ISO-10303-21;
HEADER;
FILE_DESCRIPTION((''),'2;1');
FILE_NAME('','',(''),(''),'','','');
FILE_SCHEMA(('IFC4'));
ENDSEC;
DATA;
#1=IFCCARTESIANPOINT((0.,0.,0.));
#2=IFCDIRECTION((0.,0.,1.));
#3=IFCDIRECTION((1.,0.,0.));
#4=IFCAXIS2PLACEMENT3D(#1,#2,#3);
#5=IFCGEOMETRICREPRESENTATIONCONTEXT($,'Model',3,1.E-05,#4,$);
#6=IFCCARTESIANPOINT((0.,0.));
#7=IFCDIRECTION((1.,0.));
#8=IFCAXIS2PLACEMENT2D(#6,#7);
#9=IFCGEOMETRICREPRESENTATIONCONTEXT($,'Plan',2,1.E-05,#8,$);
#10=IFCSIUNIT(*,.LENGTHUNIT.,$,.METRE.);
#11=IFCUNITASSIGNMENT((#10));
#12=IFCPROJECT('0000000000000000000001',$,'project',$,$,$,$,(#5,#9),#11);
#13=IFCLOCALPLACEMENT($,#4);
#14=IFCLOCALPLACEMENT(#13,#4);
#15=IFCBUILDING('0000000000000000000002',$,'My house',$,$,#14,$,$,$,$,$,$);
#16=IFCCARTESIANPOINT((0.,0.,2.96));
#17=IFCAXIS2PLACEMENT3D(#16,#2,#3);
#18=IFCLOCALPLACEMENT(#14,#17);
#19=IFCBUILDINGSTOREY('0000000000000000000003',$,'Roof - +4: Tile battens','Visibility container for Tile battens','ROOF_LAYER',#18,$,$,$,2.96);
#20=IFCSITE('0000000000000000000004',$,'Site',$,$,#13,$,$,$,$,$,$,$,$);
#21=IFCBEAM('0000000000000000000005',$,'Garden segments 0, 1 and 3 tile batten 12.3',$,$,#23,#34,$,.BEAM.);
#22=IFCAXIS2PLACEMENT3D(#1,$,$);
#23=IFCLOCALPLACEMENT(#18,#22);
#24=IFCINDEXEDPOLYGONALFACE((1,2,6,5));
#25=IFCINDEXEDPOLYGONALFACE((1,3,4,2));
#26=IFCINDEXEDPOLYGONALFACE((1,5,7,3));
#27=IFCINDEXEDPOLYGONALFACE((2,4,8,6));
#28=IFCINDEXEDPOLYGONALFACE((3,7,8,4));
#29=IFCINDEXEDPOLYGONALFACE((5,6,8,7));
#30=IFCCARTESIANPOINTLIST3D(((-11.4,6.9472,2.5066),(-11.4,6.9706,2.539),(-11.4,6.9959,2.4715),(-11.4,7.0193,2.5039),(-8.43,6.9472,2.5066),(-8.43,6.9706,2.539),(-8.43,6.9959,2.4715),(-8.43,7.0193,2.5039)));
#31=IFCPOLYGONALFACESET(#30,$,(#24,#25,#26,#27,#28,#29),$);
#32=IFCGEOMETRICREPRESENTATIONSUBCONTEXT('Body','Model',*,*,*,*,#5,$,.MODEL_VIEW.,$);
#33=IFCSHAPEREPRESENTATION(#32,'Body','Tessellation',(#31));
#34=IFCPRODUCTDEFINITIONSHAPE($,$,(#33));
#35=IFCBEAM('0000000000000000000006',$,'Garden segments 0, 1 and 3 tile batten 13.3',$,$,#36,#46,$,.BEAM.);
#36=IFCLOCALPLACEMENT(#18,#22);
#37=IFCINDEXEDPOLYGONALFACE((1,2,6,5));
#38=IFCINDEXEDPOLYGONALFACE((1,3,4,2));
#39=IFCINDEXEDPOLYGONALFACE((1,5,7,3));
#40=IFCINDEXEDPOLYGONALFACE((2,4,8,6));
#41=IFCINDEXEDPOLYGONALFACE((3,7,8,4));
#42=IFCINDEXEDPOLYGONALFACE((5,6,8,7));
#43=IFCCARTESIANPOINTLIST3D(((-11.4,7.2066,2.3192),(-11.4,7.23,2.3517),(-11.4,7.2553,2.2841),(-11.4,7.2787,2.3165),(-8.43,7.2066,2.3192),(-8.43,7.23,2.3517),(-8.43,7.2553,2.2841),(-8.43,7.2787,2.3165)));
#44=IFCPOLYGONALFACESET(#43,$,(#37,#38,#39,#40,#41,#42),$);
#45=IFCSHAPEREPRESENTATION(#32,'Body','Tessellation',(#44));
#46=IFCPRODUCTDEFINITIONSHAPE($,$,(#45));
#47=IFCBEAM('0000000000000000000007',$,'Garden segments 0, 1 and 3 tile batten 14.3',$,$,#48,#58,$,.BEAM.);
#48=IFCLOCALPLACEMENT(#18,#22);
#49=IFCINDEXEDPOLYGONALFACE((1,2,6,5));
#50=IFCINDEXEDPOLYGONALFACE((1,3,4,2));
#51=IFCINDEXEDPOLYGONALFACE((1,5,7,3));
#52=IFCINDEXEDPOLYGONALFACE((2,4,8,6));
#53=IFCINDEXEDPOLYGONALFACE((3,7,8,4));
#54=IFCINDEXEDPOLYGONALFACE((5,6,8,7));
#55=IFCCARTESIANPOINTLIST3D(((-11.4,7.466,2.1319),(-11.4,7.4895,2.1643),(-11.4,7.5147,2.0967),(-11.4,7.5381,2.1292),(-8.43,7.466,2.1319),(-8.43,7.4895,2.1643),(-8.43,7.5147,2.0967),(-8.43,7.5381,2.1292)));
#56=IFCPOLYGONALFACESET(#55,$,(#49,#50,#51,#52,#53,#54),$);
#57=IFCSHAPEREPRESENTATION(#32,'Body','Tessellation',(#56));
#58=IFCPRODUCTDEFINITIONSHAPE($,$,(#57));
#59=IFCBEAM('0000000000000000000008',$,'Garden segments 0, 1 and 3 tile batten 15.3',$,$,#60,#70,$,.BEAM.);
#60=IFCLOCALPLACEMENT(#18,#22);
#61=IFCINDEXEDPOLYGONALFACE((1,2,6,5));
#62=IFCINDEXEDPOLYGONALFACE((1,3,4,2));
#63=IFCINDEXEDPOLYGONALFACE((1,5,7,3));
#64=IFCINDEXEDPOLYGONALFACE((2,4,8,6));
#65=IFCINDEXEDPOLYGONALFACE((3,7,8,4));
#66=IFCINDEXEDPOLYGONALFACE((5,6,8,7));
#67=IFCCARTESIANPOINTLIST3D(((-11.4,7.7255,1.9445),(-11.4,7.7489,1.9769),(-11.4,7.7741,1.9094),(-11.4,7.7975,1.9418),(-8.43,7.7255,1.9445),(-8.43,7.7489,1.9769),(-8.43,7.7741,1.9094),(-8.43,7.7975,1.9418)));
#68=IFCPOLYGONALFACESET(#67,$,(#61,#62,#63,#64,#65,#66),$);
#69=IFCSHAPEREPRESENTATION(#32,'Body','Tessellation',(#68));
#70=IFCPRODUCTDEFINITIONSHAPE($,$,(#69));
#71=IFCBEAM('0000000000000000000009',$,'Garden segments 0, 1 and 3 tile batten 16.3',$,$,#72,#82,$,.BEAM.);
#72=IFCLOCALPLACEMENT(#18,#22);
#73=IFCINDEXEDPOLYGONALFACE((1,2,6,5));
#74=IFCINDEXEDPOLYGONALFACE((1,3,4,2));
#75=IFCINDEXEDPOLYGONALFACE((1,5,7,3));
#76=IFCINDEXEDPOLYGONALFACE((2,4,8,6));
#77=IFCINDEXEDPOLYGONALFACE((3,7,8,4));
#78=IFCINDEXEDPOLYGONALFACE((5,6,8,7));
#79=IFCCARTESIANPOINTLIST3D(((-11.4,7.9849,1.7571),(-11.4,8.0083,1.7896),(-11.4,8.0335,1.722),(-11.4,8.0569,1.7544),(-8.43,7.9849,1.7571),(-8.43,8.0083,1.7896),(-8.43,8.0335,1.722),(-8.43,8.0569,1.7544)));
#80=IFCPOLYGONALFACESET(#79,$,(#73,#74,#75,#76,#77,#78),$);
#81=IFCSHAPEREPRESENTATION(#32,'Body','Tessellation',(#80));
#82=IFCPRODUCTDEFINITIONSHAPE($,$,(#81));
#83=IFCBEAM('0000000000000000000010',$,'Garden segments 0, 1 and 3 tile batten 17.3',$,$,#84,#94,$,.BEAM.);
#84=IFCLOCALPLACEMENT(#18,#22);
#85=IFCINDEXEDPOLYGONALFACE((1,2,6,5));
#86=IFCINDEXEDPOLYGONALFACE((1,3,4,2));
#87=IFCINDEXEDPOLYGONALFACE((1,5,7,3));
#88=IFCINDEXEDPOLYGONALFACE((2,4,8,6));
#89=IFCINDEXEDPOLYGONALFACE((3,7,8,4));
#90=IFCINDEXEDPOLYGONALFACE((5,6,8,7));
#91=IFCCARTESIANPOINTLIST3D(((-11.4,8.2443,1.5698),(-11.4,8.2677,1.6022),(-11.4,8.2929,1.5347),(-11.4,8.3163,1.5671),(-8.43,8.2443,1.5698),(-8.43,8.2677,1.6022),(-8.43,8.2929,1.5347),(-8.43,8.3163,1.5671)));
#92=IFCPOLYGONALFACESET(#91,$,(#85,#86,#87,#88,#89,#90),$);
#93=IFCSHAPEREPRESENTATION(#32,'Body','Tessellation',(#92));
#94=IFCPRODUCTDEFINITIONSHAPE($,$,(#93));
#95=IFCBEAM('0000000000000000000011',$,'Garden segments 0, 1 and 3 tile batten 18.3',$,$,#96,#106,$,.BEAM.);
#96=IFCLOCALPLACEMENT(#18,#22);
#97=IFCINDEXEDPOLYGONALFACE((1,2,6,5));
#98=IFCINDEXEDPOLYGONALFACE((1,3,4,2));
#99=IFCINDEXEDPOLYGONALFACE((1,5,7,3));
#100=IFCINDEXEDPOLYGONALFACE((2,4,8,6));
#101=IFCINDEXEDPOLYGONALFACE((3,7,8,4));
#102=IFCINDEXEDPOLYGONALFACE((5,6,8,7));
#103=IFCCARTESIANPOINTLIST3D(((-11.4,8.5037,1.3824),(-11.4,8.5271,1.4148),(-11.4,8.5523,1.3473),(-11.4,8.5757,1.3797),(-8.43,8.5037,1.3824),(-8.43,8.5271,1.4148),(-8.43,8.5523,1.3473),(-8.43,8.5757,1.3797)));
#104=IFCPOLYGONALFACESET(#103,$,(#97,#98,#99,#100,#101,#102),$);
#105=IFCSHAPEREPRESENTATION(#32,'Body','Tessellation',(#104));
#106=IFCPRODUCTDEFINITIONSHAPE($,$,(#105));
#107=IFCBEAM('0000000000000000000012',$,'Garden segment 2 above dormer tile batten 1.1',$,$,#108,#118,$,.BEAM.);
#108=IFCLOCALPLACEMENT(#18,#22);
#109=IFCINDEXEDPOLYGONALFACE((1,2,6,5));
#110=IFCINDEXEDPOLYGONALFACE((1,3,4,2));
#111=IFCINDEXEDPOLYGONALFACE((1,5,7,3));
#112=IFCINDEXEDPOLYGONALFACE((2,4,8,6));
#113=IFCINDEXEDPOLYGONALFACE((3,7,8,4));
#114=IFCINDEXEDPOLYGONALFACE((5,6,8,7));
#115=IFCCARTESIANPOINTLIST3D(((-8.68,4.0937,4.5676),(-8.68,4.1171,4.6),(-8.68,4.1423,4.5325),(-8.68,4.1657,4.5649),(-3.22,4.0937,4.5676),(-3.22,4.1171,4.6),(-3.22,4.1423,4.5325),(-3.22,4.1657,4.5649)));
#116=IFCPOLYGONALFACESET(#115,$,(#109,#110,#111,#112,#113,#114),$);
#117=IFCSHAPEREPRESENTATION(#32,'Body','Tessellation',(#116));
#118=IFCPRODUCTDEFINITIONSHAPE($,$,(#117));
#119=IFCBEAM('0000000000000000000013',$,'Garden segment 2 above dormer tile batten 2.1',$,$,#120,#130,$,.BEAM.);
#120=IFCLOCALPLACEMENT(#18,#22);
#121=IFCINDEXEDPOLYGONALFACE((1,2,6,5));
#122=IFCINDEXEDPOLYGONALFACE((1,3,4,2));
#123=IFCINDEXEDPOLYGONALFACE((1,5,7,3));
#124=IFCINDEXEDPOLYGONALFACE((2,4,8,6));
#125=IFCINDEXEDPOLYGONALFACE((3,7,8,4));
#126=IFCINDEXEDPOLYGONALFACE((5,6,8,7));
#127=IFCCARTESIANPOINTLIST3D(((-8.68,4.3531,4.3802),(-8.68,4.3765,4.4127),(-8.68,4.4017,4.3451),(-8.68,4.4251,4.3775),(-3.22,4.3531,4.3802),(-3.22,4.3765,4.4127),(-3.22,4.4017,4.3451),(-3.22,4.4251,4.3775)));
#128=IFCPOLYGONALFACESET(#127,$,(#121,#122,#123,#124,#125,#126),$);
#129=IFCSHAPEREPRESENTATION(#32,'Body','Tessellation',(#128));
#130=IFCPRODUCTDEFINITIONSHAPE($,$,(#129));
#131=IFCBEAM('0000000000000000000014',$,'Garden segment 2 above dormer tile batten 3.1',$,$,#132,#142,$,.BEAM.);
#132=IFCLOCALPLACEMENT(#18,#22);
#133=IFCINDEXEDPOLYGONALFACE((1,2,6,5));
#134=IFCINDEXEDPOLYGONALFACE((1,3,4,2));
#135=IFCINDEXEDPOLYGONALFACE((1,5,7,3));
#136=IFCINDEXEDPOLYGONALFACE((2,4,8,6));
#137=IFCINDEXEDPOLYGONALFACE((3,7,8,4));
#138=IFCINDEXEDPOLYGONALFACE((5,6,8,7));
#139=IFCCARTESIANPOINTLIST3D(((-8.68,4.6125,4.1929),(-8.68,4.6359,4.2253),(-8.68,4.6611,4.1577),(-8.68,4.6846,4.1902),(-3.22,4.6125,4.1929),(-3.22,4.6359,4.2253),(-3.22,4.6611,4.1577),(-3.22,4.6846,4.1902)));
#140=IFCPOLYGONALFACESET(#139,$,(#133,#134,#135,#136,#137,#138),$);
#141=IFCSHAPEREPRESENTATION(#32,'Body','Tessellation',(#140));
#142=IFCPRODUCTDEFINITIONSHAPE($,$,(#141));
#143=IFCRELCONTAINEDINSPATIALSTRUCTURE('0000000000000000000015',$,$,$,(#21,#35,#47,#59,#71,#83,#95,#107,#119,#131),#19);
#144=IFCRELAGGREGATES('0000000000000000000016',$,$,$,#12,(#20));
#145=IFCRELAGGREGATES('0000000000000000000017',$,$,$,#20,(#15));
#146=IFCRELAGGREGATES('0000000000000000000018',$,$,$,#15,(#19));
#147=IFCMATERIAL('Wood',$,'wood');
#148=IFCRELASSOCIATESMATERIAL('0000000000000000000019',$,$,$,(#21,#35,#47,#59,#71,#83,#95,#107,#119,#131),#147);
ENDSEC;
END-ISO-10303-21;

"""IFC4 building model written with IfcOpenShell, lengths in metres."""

from ifc_helpers import new_model, si_unit, frame, origin_with_axes, origin_2d_with_axis, place, context, subcontext, project, spatial, rectangle, extrude, clip, halfspace, source, transform, mapped, material, element, save


model = new_model("IFC4")

# Units and contexts
model_context = context("Model", 3, precision=1e-05, world=origin_with_axes())
plan_context = context("Plan", 2, precision=1e-05, world=origin_2d_with_axis())
body_context = subcontext(model_context, "Body", "Model", "MODEL_VIEW")
ifc_project = project(units=[si_unit("LENGTHUNIT", "METRE")], contexts=[model_context, plan_context])

# Site, building, storey
site_placement = place(None, origin_with_axes())
site = spatial("IfcSite", under=ifc_project, at=site_placement, Name="Site")
building_placement = place(site_placement, origin_with_axes())
building = spatial("IfcBuilding", under=site, at=building_placement, Name="My house")
storey_placement = place(building_placement, frame((0.0, 0.0, 2.96), z_axis=(0.0, 0.0, 1.0), x_axis=(1.0, 0.0, 0.0)))
storey = spatial("IfcBuildingStorey", under=building, at=storey_placement, Name="Roof - +4: Tile battens", Description="Visibility container for Tile battens", ObjectType="ROOF_LAYER", Elevation=2.96)

# Beams
ifc_material = material(Name="Wood", Category="wood")
shared_shape_1 = source(origin_with_axes(), body_context, "Body", "Clipping", [
    clip(clip(extrude(rectangle(XDim=0.06, YDim=0.04), frame((0.0, 0.0, 0.0), z_axis=(1.0, 0.0, 0.0), x_axis=(0.0, 1.0, 0.0)), (0.0, 0.0, 1.0), 2.97), halfspace(frame((-8.43, 0.7816, -6.1772), z_axis=(0.0, -0.810664, -0.585512), x_axis=(-1.0, 0.0, 0.0)), False)), halfspace(frame((-8.43, 4.6322, -3.396), z_axis=(0.0, 0.810664, 0.585512), x_axis=(1.0, 0.0, 0.0)), False)),
])
beam_1_placement = place(storey_placement, frame((-8.43, 6.9832, 2.5053), z_axis=(0.0, 0.585512, 0.810664), x_axis=(1.0, 0.0, 0.0)))
element("IfcBeam", 1, at=beam_1_placement, inside=storey, material=ifc_material, Name="Garden segments 0, 1 and 3 tile batten 12.3", PredefinedType="BEAM", context=body_context, shape_type="MappedRepresentation", body=[
    mapped(shared_shape_1, transform((0.0, 0.0, 0.0), x_axis=(-1.0, 0.0, 0.0), y_axis=(0.0, 1.0, 0.0), z_axis=(0.0, 0.0, 1.0), scale=1.0)),
])
shared_shape_2 = source(origin_with_axes(), body_context, "Body", "Clipping", [
    clip(clip(extrude(rectangle(XDim=0.06, YDim=0.04), frame((0.0, 0.0, 0.0), z_axis=(1.0, 0.0, 0.0), x_axis=(0.0, 1.0, 0.0)), (0.0, 0.0, 1.0), 2.97), halfspace(frame((-8.43, 0.4616, -6.1772), z_axis=(0.0, -0.810664, -0.585512), x_axis=(-1.0, 0.0, 0.0)), False)), halfspace(frame((-8.43, 4.3122, -3.396), z_axis=(0.0, 0.810664, 0.585512), x_axis=(1.0, 0.0, 0.0)), False)),
])
beam_2_placement = place(storey_placement, frame((-8.43, 7.2427, 2.3179), z_axis=(0.0, 0.585512, 0.810664), x_axis=(1.0, 0.0, 0.0)))
element("IfcBeam", 2, at=beam_2_placement, inside=storey, material=ifc_material, Name="Garden segments 0, 1 and 3 tile batten 13.3", PredefinedType="BEAM", context=body_context, shape_type="MappedRepresentation", body=[
    mapped(shared_shape_2, transform((0.0, 0.0, 0.0), x_axis=(-1.0, 0.0, 0.0), y_axis=(0.0, 1.0, 0.0), z_axis=(0.0, 0.0, 1.0), scale=1.0)),
])
shared_shape_3 = source(origin_with_axes(), body_context, "Body", "Clipping", [
    clip(clip(extrude(rectangle(XDim=0.06, YDim=0.04), frame((0.0, 0.0, 0.0), z_axis=(1.0, 0.0, 0.0), x_axis=(0.0, 1.0, 0.0)), (0.0, 0.0, 1.0), 2.97), halfspace(frame((-8.43, 0.1416, -6.1772), z_axis=(0.0, -0.810664, -0.585512), x_axis=(-1.0, 0.0, 0.0)), False)), halfspace(frame((-8.43, 3.9922, -3.396), z_axis=(0.0, 0.810664, 0.585512), x_axis=(1.0, 0.0, 0.0)), False)),
])
beam_3_placement = place(storey_placement, frame((-8.43, 7.5021, 2.1305), z_axis=(0.0, 0.585512, 0.810664), x_axis=(1.0, 0.0, 0.0)))
element("IfcBeam", 3, at=beam_3_placement, inside=storey, material=ifc_material, Name="Garden segments 0, 1 and 3 tile batten 14.3", PredefinedType="BEAM", context=body_context, shape_type="MappedRepresentation", body=[
    mapped(shared_shape_3, transform((0.0, 0.0, 0.0), x_axis=(-1.0, 0.0, 0.0), y_axis=(0.0, 1.0, 0.0), z_axis=(0.0, 0.0, 1.0), scale=1.0)),
])
shared_shape_4 = source(origin_with_axes(), body_context, "Body", "Clipping", [
    clip(clip(extrude(rectangle(XDim=0.06, YDim=0.04), frame((0.0, 0.0, 0.0), z_axis=(1.0, 0.0, 0.0), x_axis=(0.0, 1.0, 0.0)), (0.0, 0.0, 1.0), 2.97), halfspace(frame((-8.43, -0.1784, -6.1772), z_axis=(0.0, -0.810664, -0.585512), x_axis=(-1.0, 0.0, 0.0)), False)), halfspace(frame((-8.43, 3.6722, -3.396), z_axis=(0.0, 0.810664, 0.585512), x_axis=(1.0, 0.0, 0.0)), False)),
])
beam_4_placement = place(storey_placement, frame((-8.43, 7.7615, 1.9432), z_axis=(0.0, 0.585512, 0.810664), x_axis=(1.0, 0.0, 0.0)))
element("IfcBeam", 4, at=beam_4_placement, inside=storey, material=ifc_material, Name="Garden segments 0, 1 and 3 tile batten 15.3", PredefinedType="BEAM", context=body_context, shape_type="MappedRepresentation", body=[
    mapped(shared_shape_4, transform((0.0, 0.0, 0.0), x_axis=(-1.0, 0.0, 0.0), y_axis=(0.0, 1.0, 0.0), z_axis=(0.0, 0.0, 1.0), scale=1.0)),
])
shared_shape_5 = source(origin_with_axes(), body_context, "Body", "Clipping", [
    clip(clip(extrude(rectangle(XDim=0.06, YDim=0.04), frame((0.0, 0.0, 0.0), z_axis=(1.0, 0.0, 0.0), x_axis=(0.0, 1.0, 0.0)), (0.0, 0.0, 1.0), 2.97), halfspace(frame((-8.43, -0.4984, -6.1772), z_axis=(0.0, -0.810664, -0.585512), x_axis=(-1.0, 0.0, 0.0)), False)), halfspace(frame((-8.43, 3.3522, -3.396), z_axis=(0.0, 0.810664, 0.585512), x_axis=(1.0, 0.0, 0.0)), False)),
])
beam_5_placement = place(storey_placement, frame((-8.43, 8.0209, 1.7558), z_axis=(0.0, 0.585512, 0.810664), x_axis=(1.0, 0.0, 0.0)))
element("IfcBeam", 5, at=beam_5_placement, inside=storey, material=ifc_material, Name="Garden segments 0, 1 and 3 tile batten 16.3", PredefinedType="BEAM", context=body_context, shape_type="MappedRepresentation", body=[
    mapped(shared_shape_5, transform((0.0, 0.0, 0.0), x_axis=(-1.0, 0.0, 0.0), y_axis=(0.0, 1.0, 0.0), z_axis=(0.0, 0.0, 1.0), scale=1.0)),
])
shared_shape_6 = source(origin_with_axes(), body_context, "Body", "Clipping", [
    clip(clip(extrude(rectangle(XDim=0.06, YDim=0.04), frame((0.0, 0.0, 0.0), z_axis=(1.0, 0.0, 0.0), x_axis=(0.0, 1.0, 0.0)), (0.0, 0.0, 1.0), 2.97), halfspace(frame((-8.43, -0.8184, -6.1772), z_axis=(0.0, -0.810664, -0.585512), x_axis=(-1.0, 0.0, 0.0)), False)), halfspace(frame((-8.43, 3.0322, -3.396), z_axis=(0.0, 0.810664, 0.585512), x_axis=(1.0, 0.0, 0.0)), False)),
])
beam_6_placement = place(storey_placement, frame((-8.43, 8.2803, 1.5684), z_axis=(0.0, 0.585512, 0.810664), x_axis=(1.0, 0.0, 0.0)))
element("IfcBeam", 6, at=beam_6_placement, inside=storey, material=ifc_material, Name="Garden segments 0, 1 and 3 tile batten 17.3", PredefinedType="BEAM", context=body_context, shape_type="MappedRepresentation", body=[
    mapped(shared_shape_6, transform((0.0, 0.0, 0.0), x_axis=(-1.0, 0.0, 0.0), y_axis=(0.0, 1.0, 0.0), z_axis=(0.0, 0.0, 1.0), scale=1.0)),
])
shared_shape_7 = source(origin_with_axes(), body_context, "Body", "Clipping", [
    clip(clip(extrude(rectangle(XDim=0.06, YDim=0.04), frame((0.0, 0.0, 0.0), z_axis=(1.0, 0.0, 0.0), x_axis=(0.0, 1.0, 0.0)), (0.0, 0.0, 1.0), 2.97), halfspace(frame((-8.43, -1.1384, -6.1772), z_axis=(0.0, -0.810664, -0.585512), x_axis=(-1.0, 0.0, 0.0)), False)), halfspace(frame((-8.43, 2.7122, -3.396), z_axis=(0.0, 0.810664, 0.585512), x_axis=(1.0, 0.0, 0.0)), False)),
])
beam_7_placement = place(storey_placement, frame((-8.43, 8.5397, 1.3811), z_axis=(0.0, 0.585512, 0.810664), x_axis=(1.0, 0.0, 0.0)))
element("IfcBeam", 7, at=beam_7_placement, inside=storey, material=ifc_material, Name="Garden segments 0, 1 and 3 tile batten 18.3", PredefinedType="BEAM", context=body_context, shape_type="MappedRepresentation", body=[
    mapped(shared_shape_7, transform((0.0, 0.0, 0.0), x_axis=(-1.0, 0.0, 0.0), y_axis=(0.0, 1.0, 0.0), z_axis=(0.0, 0.0, 1.0), scale=1.0)),
])
shared_shape_8 = source(origin_with_axes(), body_context, "Body", "Clipping", [
    clip(clip(extrude(rectangle(XDim=0.06, YDim=0.04), frame((0.0, 0.0, 0.0), z_axis=(1.0, 0.0, 0.0), x_axis=(0.0, 1.0, 0.0)), (0.0, 0.0, 1.0), 5.46), halfspace(frame((-3.22, 4.3016, -6.1772), z_axis=(0.0, -0.810664, -0.585512), x_axis=(-1.0, 0.0, 0.0)), False)), halfspace(frame((-3.22, 8.1522, -3.396), z_axis=(0.0, 0.810664, 0.585512), x_axis=(1.0, 0.0, 0.0)), False)),
])
beam_8_placement = place(storey_placement, frame((-3.22, 4.1297, 4.5663), z_axis=(0.0, 0.585512, 0.810664), x_axis=(1.0, 0.0, 0.0)))
element("IfcBeam", 8, at=beam_8_placement, inside=storey, material=ifc_material, Name="Garden segment 2 above dormer tile batten 1.1", PredefinedType="BEAM", context=body_context, shape_type="MappedRepresentation", body=[
    mapped(shared_shape_8, transform((0.0, 0.0, 0.0), x_axis=(-1.0, 0.0, 0.0), y_axis=(0.0, 1.0, 0.0), z_axis=(0.0, 0.0, 1.0), scale=1.0)),
])
shared_shape_9 = source(origin_with_axes(), body_context, "Body", "Clipping", [
    clip(clip(extrude(rectangle(XDim=0.06, YDim=0.04), frame((0.0, 0.0, 0.0), z_axis=(1.0, 0.0, 0.0), x_axis=(0.0, 1.0, 0.0)), (0.0, 0.0, 1.0), 5.46), halfspace(frame((-3.22, 3.9816, -6.1772), z_axis=(0.0, -0.810664, -0.585512), x_axis=(-1.0, 0.0, 0.0)), False)), halfspace(frame((-3.22, 7.8322, -3.396), z_axis=(0.0, 0.810664, 0.585512), x_axis=(1.0, 0.0, 0.0)), False)),
])
beam_9_placement = place(storey_placement, frame((-3.22, 4.3891, 4.3789), z_axis=(0.0, 0.585512, 0.810664), x_axis=(1.0, 0.0, 0.0)))
element("IfcBeam", 9, at=beam_9_placement, inside=storey, material=ifc_material, Name="Garden segment 2 above dormer tile batten 2.1", PredefinedType="BEAM", context=body_context, shape_type="MappedRepresentation", body=[
    mapped(shared_shape_9, transform((0.0, 0.0, 0.0), x_axis=(-1.0, 0.0, 0.0), y_axis=(0.0, 1.0, 0.0), z_axis=(0.0, 0.0, 1.0), scale=1.0)),
])
shared_shape_10 = source(origin_with_axes(), body_context, "Body", "Clipping", [
    clip(clip(extrude(rectangle(XDim=0.06, YDim=0.04), frame((0.0, 0.0, 0.0), z_axis=(1.0, 0.0, 0.0), x_axis=(0.0, 1.0, 0.0)), (0.0, 0.0, 1.0), 5.46), halfspace(frame((-3.22, 3.6616, -6.1772), z_axis=(0.0, -0.810664, -0.585512), x_axis=(-1.0, 0.0, 0.0)), False)), halfspace(frame((-3.22, 7.5122, -3.396), z_axis=(0.0, 0.810664, 0.585512), x_axis=(1.0, 0.0, 0.0)), False)),
])
beam_10_placement = place(storey_placement, frame((-3.22, 4.6485, 4.1915), z_axis=(0.0, 0.585512, 0.810664), x_axis=(1.0, 0.0, 0.0)))
element("IfcBeam", 10, at=beam_10_placement, inside=storey, material=ifc_material, Name="Garden segment 2 above dormer tile batten 3.1", PredefinedType="BEAM", context=body_context, shape_type="MappedRepresentation", body=[
    mapped(shared_shape_10, transform((0.0, 0.0, 0.0), x_axis=(-1.0, 0.0, 0.0), y_axis=(0.0, 1.0, 0.0), z_axis=(0.0, 0.0, 1.0), scale=1.0)),
])

save(model, "model.ifc")
